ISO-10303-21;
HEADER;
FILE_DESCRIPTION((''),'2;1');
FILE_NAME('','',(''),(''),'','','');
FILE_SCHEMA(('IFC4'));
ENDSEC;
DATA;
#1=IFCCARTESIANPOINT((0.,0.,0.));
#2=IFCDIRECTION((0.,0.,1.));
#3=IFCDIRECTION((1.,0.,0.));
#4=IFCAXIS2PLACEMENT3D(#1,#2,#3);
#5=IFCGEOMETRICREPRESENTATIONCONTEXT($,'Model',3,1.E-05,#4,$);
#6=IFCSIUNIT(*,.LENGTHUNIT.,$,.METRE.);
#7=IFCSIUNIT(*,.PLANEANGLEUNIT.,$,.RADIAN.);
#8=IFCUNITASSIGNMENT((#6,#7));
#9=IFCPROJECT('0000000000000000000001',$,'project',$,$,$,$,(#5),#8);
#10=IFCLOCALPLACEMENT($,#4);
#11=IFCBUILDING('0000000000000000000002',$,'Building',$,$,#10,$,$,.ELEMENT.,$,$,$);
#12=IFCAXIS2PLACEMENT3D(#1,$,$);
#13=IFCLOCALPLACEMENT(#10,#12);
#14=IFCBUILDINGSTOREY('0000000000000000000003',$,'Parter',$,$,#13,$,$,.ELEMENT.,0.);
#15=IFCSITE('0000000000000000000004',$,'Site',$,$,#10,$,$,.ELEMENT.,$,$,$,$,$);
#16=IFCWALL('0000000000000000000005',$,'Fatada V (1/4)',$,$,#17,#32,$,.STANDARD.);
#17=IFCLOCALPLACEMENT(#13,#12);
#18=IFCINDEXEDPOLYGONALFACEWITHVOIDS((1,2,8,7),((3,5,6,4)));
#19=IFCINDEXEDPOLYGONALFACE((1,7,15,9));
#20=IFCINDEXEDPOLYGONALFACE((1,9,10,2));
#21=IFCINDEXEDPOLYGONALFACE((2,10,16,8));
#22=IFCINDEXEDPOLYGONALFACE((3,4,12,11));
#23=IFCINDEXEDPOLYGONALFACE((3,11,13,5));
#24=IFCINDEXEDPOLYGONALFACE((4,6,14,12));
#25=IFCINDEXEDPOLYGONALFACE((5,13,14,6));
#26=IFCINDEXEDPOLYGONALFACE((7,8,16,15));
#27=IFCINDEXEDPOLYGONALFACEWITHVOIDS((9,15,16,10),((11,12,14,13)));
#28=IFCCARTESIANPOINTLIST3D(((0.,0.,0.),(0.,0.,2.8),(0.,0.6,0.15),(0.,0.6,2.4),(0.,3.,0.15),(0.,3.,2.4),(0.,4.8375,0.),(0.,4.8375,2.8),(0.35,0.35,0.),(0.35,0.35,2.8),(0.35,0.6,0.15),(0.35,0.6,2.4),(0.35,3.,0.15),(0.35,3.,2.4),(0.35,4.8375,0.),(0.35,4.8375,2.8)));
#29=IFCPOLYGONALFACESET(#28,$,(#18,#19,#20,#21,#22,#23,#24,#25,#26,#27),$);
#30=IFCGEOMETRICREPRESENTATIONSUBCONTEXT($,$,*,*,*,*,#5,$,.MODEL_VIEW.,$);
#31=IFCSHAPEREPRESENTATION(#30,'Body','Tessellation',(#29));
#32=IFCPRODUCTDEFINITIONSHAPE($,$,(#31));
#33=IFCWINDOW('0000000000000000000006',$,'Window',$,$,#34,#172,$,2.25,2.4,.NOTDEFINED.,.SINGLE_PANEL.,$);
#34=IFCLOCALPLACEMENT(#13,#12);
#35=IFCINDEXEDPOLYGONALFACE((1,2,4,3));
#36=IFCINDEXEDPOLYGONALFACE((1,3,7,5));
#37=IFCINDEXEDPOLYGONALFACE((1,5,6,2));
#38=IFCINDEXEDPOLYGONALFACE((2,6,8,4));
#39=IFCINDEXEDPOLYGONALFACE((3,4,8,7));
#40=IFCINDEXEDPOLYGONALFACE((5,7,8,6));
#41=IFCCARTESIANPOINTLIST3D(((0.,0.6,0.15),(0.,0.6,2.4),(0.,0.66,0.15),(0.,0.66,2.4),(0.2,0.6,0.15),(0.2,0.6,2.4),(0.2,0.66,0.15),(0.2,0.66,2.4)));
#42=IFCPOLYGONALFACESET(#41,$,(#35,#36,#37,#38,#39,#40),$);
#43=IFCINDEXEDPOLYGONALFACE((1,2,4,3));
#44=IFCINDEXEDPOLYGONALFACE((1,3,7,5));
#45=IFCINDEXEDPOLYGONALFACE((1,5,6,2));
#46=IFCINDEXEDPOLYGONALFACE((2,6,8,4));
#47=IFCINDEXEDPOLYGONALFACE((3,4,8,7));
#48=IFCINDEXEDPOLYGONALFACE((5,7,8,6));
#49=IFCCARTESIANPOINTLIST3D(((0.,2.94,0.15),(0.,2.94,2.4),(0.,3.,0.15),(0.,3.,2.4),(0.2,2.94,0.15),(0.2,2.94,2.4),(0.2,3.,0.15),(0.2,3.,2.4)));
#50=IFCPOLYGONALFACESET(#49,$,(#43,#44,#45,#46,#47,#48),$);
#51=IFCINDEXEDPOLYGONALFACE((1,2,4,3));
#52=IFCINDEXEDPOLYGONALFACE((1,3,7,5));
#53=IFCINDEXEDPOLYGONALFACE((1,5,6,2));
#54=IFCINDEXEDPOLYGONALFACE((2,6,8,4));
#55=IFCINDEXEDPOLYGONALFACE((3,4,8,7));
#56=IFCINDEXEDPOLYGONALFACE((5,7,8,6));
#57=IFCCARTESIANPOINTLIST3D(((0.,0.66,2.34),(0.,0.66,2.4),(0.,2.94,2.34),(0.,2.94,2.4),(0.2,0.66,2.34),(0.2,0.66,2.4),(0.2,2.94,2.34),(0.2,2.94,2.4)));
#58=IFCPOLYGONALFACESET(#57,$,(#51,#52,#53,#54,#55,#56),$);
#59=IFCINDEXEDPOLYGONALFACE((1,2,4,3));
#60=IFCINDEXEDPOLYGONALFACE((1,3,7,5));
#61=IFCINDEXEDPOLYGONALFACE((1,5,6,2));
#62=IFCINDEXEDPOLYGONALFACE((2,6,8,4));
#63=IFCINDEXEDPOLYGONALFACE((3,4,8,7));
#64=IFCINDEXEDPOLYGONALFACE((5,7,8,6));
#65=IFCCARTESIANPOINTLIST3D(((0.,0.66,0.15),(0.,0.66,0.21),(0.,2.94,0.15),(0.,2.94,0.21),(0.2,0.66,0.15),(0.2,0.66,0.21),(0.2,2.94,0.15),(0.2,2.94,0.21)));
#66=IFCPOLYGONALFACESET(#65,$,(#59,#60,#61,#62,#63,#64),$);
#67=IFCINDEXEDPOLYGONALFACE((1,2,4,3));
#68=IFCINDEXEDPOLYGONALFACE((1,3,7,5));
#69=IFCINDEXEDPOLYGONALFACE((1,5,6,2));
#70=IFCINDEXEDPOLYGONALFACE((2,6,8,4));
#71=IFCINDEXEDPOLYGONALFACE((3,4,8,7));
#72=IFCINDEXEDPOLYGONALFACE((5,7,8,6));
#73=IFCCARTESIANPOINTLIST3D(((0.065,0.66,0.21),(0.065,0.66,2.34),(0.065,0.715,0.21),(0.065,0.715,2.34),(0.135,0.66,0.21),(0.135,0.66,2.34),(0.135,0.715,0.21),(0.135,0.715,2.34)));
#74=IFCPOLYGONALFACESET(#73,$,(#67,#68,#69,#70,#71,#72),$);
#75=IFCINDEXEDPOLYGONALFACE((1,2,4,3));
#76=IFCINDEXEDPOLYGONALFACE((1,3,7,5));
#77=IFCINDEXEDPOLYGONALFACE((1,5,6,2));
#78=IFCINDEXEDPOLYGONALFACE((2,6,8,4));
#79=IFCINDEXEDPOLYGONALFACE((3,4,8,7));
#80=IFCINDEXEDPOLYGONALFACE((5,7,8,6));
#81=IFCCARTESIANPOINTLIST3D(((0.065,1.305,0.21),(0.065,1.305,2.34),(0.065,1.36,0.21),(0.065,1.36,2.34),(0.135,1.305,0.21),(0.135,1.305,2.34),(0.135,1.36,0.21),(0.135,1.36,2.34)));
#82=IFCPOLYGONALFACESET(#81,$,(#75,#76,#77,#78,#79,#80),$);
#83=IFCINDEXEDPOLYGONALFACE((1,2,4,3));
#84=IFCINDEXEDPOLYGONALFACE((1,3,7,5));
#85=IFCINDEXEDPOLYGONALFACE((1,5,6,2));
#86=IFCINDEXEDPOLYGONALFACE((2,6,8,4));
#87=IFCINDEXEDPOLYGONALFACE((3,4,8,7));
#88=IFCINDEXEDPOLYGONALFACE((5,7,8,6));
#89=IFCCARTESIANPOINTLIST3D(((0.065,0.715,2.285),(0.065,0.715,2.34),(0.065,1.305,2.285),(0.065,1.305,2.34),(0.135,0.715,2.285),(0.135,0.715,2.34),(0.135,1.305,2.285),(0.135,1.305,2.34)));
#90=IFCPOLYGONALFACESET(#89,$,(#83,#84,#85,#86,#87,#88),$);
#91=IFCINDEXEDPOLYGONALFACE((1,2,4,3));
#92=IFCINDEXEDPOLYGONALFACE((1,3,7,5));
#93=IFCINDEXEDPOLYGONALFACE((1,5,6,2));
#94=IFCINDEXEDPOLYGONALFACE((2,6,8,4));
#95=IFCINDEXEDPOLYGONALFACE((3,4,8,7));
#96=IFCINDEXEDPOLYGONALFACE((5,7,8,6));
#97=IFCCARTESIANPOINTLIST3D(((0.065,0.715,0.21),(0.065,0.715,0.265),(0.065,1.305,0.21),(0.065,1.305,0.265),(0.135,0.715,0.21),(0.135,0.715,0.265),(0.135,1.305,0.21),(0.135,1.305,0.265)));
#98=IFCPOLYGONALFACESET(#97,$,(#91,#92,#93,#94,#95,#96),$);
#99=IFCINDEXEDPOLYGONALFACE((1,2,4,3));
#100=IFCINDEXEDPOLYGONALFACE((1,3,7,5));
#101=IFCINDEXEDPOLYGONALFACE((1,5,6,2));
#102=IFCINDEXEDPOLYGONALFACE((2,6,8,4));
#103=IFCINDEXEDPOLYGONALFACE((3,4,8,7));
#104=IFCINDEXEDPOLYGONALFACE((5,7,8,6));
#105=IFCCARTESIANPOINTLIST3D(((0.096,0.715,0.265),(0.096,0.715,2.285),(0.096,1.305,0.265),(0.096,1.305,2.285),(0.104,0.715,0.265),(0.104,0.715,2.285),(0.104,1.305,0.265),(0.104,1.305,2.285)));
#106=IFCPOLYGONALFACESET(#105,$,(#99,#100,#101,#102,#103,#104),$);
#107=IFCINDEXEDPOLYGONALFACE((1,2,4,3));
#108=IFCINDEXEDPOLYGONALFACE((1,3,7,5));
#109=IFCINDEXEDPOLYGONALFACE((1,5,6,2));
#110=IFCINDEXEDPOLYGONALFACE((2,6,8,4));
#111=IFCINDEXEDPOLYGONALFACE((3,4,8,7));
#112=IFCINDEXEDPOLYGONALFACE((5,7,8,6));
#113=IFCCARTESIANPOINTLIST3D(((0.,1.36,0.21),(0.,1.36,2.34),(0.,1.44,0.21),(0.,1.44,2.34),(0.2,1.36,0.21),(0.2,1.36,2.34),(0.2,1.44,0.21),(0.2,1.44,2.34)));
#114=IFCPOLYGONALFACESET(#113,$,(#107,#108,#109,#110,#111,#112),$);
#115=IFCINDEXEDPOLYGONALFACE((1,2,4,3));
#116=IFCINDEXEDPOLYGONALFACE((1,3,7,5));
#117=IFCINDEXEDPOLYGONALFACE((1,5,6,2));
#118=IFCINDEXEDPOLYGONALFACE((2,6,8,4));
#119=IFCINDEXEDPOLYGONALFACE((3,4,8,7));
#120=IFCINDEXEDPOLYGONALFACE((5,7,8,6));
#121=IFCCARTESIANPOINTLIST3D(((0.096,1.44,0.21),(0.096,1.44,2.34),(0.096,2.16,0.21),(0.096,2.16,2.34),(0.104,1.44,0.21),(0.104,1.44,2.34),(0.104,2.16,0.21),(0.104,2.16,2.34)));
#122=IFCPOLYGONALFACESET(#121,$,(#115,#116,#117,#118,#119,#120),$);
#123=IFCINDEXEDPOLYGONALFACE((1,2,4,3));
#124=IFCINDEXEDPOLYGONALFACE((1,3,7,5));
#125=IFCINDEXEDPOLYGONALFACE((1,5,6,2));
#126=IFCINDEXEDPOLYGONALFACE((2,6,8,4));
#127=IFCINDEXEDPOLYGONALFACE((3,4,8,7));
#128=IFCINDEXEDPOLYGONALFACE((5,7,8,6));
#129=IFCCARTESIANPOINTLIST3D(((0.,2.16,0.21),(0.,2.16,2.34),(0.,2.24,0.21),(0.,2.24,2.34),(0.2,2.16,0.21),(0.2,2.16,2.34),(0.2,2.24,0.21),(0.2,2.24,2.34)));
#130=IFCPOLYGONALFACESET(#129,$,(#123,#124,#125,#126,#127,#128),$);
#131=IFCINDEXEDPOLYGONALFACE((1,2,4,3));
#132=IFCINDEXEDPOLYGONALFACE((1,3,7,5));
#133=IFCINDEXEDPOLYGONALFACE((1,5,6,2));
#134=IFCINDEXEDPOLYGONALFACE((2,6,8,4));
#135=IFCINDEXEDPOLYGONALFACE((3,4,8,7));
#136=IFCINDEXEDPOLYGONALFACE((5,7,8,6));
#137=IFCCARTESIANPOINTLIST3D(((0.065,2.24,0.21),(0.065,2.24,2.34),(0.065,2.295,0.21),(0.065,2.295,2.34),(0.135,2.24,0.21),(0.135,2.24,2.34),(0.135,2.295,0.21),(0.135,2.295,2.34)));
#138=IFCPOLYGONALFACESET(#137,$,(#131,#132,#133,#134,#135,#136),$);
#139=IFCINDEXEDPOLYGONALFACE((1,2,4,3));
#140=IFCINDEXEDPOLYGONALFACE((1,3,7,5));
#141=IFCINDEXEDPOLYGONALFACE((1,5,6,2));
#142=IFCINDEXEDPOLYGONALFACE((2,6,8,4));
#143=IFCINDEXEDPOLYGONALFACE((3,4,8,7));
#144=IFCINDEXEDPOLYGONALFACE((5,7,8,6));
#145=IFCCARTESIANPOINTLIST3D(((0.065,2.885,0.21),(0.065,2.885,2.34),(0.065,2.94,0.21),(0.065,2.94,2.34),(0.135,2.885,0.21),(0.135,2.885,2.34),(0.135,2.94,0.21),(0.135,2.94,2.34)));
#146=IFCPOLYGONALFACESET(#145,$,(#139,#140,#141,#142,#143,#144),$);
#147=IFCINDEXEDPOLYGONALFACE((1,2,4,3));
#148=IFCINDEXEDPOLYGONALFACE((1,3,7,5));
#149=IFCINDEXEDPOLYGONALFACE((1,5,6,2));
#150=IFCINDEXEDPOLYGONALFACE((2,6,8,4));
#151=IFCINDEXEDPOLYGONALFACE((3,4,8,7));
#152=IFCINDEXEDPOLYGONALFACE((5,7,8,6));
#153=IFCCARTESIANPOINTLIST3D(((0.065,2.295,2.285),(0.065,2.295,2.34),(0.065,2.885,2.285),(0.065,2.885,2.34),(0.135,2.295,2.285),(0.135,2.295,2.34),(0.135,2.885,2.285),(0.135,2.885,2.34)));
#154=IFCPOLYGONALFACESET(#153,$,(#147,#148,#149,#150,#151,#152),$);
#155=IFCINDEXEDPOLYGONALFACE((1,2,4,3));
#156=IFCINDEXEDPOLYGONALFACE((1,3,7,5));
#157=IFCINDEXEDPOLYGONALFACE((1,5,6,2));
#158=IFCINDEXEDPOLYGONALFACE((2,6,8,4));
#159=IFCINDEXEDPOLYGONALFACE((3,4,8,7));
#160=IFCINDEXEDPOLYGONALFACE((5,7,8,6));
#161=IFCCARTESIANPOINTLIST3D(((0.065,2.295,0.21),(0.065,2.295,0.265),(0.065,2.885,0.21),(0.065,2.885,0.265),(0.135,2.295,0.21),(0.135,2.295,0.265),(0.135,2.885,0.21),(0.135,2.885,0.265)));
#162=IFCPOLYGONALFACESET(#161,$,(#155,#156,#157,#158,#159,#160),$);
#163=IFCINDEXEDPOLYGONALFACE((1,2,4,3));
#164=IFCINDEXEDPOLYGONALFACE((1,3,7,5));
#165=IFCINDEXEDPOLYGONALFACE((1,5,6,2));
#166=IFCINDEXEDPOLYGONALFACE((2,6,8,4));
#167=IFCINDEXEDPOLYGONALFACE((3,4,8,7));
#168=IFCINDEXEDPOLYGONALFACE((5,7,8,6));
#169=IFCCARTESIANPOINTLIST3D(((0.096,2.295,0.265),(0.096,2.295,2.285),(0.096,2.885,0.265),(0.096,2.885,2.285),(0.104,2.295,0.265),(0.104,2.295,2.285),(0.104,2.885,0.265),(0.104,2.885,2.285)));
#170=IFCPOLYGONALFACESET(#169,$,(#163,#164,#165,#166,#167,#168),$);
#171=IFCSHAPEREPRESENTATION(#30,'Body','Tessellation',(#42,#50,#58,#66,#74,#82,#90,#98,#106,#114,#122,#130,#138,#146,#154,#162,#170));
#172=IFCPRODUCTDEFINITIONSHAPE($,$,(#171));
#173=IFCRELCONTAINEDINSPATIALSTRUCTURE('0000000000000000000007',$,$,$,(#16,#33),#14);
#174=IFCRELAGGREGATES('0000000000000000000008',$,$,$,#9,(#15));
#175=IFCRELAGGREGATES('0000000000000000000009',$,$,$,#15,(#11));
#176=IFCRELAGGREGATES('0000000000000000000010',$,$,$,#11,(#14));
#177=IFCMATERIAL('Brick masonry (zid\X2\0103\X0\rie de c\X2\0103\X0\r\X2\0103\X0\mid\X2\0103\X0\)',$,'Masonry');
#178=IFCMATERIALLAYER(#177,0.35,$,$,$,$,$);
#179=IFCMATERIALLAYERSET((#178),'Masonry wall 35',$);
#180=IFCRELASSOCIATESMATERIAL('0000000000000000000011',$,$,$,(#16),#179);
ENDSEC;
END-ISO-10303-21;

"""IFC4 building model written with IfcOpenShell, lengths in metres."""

from ifc_helpers import new_model, si_unit, frame, frame_2d, origin, origin_with_axes, origin_2d, place, context, subcontext, project, spatial, rectangle, extrude, clip, halfspace, material, layer, layer_set, layer_usage, element, fill, save


model = new_model("IFC4")

# Units and contexts
model_context = context("Model", 3, precision=1e-05, world=origin_with_axes())
sub_context = subcontext(model_context, None, None, "MODEL_VIEW")
ifc_project = project(units=[si_unit("LENGTHUNIT", "METRE"), si_unit("PLANEANGLEUNIT", "RADIAN")], contexts=[model_context])

# Site, building, storey
placement = place(None, origin_with_axes())
site = spatial("IfcSite", under=ifc_project, at=placement, Name="Site", CompositionType="ELEMENT")
building = spatial("IfcBuilding", under=site, at=placement, Name="Building", CompositionType="ELEMENT")
storey_placement = place(placement, origin())
storey = spatial("IfcBuildingStorey", under=building, at=storey_placement, Name="Parter", CompositionType="ELEMENT", Elevation=0.0)

# Wall, opening, window
ifc_material_1 = material(Name="Brick masonry (zidărie de cărămidă)", Category="Masonry")
ifc_layer_1 = layer(ifc_material_1, 0.35)
ifc_layer_set_1 = layer_set([ifc_layer_1], Name="Masonry wall 35")
ifc_layer_usage_1 = layer_usage(ifc_layer_set_1, "AXIS2", "POSITIVE", -0.175)
wall_1_placement = place(storey_placement, frame((0.175, 0.0, 0.0), x_axis=(0.0, 1.0, 0.0)))
wall_1 = element("IfcWall", 1, at=wall_1_placement, inside=storey, material=ifc_layer_usage_1, Name="Fatada V (1/4)", PredefinedType="STANDARD", context=sub_context, shape_type="CSG", body=[
    clip(extrude(rectangle(XDim=4.8375, YDim=0.35, at=frame_2d((2.4188, 0.0))), origin(), (0.0, 0.0, 1.0), 2.8), halfspace(frame((0.175, 0.0, 0.0), z_axis=(-0.707107, -0.707107, 0.0)), False)),
])
opening_1_placement = place(wall_1_placement, frame((1.8, 0.225, 0.15), z_axis=(0.0, -1.0, 0.0), x_axis=(1.0, 0.0, 0.0)))
opening_1 = element("IfcOpeningElement", 2, at=opening_1_placement, cuts=wall_1, PredefinedType="OPENING", context=sub_context, shape_type="SweptSolid", body=[
    extrude(rectangle(XDim=2.4, YDim=2.25, at=frame_2d((0.0, 1.125))), origin(), (0.0, 0.0, 1.0), 0.45),
])
window_1_placement = place(wall_1_placement, frame((1.8, 0.175, 0.15), z_axis=(0.0, -1.0, 0.0), x_axis=(1.0, 0.0, 0.0)))
window_1 = element("IfcWindow", 3, at=window_1_placement, inside=storey, Name="Window", OverallHeight=2.25, OverallWidth=2.4, PartitioningType="SINGLE_PANEL", PredefinedType="NOTDEFINED", context=sub_context, shape_type="SweptSolid", body=[
    extrude(rectangle(XDim=0.06, YDim=2.25, at=origin_2d()), frame((-1.17, 1.125, 0.0)), (0.0, 0.0, 1.0), 0.2),
    extrude(rectangle(XDim=0.06, YDim=2.25, at=origin_2d()), frame((1.17, 1.125, 0.0)), (0.0, 0.0, 1.0), 0.2),
    extrude(rectangle(XDim=2.28, YDim=0.06, at=origin_2d()), frame((0.0, 2.22, 0.0)), (0.0, 0.0, 1.0), 0.2),
    extrude(rectangle(XDim=2.28, YDim=0.06, at=origin_2d()), frame((0.0, 0.03, 0.0)), (0.0, 0.0, 1.0), 0.2),
    extrude(rectangle(XDim=0.055, YDim=2.13, at=origin_2d()), frame((-1.1125, 1.125, 0.065)), (0.0, 0.0, 1.0), 0.07),
    extrude(rectangle(XDim=0.055, YDim=2.13, at=origin_2d()), frame((-0.4675, 1.125, 0.065)), (0.0, 0.0, 1.0), 0.07),
    extrude(rectangle(XDim=0.59, YDim=0.055, at=origin_2d()), frame((-0.79, 2.1625, 0.065)), (0.0, 0.0, 1.0), 0.07),
    extrude(rectangle(XDim=0.59, YDim=0.055, at=origin_2d()), frame((-0.79, 0.0875, 0.065)), (0.0, 0.0, 1.0), 0.07),
    extrude(rectangle(XDim=0.59, YDim=2.02, at=origin_2d()), frame((-0.79, 1.125, 0.096)), (0.0, 0.0, 1.0), 0.008),
    extrude(rectangle(XDim=0.08, YDim=2.13, at=origin_2d()), frame((-0.4, 1.125, 0.0)), (0.0, 0.0, 1.0), 0.2),
    extrude(rectangle(XDim=0.72, YDim=2.13, at=origin_2d()), frame((0.0, 1.125, 0.096)), (0.0, 0.0, 1.0), 0.008),
    extrude(rectangle(XDim=0.08, YDim=2.13, at=origin_2d()), frame((0.4, 1.125, 0.0)), (0.0, 0.0, 1.0), 0.2),
    extrude(rectangle(XDim=0.055, YDim=2.13, at=origin_2d()), frame((0.4675, 1.125, 0.065)), (0.0, 0.0, 1.0), 0.07),
    extrude(rectangle(XDim=0.055, YDim=2.13, at=origin_2d()), frame((1.1125, 1.125, 0.065)), (0.0, 0.0, 1.0), 0.07),
    extrude(rectangle(XDim=0.59, YDim=0.055, at=origin_2d()), frame((0.79, 2.1625, 0.065)), (0.0, 0.0, 1.0), 0.07),
    extrude(rectangle(XDim=0.59, YDim=0.055, at=origin_2d()), frame((0.79, 0.0875, 0.065)), (0.0, 0.0, 1.0), 0.07),
    extrude(rectangle(XDim=0.59, YDim=2.02, at=origin_2d()), frame((0.79, 1.125, 0.096)), (0.0, 0.0, 1.0), 0.008),
])
fill(opening_1, window_1)

save(model, "model.ifc")
